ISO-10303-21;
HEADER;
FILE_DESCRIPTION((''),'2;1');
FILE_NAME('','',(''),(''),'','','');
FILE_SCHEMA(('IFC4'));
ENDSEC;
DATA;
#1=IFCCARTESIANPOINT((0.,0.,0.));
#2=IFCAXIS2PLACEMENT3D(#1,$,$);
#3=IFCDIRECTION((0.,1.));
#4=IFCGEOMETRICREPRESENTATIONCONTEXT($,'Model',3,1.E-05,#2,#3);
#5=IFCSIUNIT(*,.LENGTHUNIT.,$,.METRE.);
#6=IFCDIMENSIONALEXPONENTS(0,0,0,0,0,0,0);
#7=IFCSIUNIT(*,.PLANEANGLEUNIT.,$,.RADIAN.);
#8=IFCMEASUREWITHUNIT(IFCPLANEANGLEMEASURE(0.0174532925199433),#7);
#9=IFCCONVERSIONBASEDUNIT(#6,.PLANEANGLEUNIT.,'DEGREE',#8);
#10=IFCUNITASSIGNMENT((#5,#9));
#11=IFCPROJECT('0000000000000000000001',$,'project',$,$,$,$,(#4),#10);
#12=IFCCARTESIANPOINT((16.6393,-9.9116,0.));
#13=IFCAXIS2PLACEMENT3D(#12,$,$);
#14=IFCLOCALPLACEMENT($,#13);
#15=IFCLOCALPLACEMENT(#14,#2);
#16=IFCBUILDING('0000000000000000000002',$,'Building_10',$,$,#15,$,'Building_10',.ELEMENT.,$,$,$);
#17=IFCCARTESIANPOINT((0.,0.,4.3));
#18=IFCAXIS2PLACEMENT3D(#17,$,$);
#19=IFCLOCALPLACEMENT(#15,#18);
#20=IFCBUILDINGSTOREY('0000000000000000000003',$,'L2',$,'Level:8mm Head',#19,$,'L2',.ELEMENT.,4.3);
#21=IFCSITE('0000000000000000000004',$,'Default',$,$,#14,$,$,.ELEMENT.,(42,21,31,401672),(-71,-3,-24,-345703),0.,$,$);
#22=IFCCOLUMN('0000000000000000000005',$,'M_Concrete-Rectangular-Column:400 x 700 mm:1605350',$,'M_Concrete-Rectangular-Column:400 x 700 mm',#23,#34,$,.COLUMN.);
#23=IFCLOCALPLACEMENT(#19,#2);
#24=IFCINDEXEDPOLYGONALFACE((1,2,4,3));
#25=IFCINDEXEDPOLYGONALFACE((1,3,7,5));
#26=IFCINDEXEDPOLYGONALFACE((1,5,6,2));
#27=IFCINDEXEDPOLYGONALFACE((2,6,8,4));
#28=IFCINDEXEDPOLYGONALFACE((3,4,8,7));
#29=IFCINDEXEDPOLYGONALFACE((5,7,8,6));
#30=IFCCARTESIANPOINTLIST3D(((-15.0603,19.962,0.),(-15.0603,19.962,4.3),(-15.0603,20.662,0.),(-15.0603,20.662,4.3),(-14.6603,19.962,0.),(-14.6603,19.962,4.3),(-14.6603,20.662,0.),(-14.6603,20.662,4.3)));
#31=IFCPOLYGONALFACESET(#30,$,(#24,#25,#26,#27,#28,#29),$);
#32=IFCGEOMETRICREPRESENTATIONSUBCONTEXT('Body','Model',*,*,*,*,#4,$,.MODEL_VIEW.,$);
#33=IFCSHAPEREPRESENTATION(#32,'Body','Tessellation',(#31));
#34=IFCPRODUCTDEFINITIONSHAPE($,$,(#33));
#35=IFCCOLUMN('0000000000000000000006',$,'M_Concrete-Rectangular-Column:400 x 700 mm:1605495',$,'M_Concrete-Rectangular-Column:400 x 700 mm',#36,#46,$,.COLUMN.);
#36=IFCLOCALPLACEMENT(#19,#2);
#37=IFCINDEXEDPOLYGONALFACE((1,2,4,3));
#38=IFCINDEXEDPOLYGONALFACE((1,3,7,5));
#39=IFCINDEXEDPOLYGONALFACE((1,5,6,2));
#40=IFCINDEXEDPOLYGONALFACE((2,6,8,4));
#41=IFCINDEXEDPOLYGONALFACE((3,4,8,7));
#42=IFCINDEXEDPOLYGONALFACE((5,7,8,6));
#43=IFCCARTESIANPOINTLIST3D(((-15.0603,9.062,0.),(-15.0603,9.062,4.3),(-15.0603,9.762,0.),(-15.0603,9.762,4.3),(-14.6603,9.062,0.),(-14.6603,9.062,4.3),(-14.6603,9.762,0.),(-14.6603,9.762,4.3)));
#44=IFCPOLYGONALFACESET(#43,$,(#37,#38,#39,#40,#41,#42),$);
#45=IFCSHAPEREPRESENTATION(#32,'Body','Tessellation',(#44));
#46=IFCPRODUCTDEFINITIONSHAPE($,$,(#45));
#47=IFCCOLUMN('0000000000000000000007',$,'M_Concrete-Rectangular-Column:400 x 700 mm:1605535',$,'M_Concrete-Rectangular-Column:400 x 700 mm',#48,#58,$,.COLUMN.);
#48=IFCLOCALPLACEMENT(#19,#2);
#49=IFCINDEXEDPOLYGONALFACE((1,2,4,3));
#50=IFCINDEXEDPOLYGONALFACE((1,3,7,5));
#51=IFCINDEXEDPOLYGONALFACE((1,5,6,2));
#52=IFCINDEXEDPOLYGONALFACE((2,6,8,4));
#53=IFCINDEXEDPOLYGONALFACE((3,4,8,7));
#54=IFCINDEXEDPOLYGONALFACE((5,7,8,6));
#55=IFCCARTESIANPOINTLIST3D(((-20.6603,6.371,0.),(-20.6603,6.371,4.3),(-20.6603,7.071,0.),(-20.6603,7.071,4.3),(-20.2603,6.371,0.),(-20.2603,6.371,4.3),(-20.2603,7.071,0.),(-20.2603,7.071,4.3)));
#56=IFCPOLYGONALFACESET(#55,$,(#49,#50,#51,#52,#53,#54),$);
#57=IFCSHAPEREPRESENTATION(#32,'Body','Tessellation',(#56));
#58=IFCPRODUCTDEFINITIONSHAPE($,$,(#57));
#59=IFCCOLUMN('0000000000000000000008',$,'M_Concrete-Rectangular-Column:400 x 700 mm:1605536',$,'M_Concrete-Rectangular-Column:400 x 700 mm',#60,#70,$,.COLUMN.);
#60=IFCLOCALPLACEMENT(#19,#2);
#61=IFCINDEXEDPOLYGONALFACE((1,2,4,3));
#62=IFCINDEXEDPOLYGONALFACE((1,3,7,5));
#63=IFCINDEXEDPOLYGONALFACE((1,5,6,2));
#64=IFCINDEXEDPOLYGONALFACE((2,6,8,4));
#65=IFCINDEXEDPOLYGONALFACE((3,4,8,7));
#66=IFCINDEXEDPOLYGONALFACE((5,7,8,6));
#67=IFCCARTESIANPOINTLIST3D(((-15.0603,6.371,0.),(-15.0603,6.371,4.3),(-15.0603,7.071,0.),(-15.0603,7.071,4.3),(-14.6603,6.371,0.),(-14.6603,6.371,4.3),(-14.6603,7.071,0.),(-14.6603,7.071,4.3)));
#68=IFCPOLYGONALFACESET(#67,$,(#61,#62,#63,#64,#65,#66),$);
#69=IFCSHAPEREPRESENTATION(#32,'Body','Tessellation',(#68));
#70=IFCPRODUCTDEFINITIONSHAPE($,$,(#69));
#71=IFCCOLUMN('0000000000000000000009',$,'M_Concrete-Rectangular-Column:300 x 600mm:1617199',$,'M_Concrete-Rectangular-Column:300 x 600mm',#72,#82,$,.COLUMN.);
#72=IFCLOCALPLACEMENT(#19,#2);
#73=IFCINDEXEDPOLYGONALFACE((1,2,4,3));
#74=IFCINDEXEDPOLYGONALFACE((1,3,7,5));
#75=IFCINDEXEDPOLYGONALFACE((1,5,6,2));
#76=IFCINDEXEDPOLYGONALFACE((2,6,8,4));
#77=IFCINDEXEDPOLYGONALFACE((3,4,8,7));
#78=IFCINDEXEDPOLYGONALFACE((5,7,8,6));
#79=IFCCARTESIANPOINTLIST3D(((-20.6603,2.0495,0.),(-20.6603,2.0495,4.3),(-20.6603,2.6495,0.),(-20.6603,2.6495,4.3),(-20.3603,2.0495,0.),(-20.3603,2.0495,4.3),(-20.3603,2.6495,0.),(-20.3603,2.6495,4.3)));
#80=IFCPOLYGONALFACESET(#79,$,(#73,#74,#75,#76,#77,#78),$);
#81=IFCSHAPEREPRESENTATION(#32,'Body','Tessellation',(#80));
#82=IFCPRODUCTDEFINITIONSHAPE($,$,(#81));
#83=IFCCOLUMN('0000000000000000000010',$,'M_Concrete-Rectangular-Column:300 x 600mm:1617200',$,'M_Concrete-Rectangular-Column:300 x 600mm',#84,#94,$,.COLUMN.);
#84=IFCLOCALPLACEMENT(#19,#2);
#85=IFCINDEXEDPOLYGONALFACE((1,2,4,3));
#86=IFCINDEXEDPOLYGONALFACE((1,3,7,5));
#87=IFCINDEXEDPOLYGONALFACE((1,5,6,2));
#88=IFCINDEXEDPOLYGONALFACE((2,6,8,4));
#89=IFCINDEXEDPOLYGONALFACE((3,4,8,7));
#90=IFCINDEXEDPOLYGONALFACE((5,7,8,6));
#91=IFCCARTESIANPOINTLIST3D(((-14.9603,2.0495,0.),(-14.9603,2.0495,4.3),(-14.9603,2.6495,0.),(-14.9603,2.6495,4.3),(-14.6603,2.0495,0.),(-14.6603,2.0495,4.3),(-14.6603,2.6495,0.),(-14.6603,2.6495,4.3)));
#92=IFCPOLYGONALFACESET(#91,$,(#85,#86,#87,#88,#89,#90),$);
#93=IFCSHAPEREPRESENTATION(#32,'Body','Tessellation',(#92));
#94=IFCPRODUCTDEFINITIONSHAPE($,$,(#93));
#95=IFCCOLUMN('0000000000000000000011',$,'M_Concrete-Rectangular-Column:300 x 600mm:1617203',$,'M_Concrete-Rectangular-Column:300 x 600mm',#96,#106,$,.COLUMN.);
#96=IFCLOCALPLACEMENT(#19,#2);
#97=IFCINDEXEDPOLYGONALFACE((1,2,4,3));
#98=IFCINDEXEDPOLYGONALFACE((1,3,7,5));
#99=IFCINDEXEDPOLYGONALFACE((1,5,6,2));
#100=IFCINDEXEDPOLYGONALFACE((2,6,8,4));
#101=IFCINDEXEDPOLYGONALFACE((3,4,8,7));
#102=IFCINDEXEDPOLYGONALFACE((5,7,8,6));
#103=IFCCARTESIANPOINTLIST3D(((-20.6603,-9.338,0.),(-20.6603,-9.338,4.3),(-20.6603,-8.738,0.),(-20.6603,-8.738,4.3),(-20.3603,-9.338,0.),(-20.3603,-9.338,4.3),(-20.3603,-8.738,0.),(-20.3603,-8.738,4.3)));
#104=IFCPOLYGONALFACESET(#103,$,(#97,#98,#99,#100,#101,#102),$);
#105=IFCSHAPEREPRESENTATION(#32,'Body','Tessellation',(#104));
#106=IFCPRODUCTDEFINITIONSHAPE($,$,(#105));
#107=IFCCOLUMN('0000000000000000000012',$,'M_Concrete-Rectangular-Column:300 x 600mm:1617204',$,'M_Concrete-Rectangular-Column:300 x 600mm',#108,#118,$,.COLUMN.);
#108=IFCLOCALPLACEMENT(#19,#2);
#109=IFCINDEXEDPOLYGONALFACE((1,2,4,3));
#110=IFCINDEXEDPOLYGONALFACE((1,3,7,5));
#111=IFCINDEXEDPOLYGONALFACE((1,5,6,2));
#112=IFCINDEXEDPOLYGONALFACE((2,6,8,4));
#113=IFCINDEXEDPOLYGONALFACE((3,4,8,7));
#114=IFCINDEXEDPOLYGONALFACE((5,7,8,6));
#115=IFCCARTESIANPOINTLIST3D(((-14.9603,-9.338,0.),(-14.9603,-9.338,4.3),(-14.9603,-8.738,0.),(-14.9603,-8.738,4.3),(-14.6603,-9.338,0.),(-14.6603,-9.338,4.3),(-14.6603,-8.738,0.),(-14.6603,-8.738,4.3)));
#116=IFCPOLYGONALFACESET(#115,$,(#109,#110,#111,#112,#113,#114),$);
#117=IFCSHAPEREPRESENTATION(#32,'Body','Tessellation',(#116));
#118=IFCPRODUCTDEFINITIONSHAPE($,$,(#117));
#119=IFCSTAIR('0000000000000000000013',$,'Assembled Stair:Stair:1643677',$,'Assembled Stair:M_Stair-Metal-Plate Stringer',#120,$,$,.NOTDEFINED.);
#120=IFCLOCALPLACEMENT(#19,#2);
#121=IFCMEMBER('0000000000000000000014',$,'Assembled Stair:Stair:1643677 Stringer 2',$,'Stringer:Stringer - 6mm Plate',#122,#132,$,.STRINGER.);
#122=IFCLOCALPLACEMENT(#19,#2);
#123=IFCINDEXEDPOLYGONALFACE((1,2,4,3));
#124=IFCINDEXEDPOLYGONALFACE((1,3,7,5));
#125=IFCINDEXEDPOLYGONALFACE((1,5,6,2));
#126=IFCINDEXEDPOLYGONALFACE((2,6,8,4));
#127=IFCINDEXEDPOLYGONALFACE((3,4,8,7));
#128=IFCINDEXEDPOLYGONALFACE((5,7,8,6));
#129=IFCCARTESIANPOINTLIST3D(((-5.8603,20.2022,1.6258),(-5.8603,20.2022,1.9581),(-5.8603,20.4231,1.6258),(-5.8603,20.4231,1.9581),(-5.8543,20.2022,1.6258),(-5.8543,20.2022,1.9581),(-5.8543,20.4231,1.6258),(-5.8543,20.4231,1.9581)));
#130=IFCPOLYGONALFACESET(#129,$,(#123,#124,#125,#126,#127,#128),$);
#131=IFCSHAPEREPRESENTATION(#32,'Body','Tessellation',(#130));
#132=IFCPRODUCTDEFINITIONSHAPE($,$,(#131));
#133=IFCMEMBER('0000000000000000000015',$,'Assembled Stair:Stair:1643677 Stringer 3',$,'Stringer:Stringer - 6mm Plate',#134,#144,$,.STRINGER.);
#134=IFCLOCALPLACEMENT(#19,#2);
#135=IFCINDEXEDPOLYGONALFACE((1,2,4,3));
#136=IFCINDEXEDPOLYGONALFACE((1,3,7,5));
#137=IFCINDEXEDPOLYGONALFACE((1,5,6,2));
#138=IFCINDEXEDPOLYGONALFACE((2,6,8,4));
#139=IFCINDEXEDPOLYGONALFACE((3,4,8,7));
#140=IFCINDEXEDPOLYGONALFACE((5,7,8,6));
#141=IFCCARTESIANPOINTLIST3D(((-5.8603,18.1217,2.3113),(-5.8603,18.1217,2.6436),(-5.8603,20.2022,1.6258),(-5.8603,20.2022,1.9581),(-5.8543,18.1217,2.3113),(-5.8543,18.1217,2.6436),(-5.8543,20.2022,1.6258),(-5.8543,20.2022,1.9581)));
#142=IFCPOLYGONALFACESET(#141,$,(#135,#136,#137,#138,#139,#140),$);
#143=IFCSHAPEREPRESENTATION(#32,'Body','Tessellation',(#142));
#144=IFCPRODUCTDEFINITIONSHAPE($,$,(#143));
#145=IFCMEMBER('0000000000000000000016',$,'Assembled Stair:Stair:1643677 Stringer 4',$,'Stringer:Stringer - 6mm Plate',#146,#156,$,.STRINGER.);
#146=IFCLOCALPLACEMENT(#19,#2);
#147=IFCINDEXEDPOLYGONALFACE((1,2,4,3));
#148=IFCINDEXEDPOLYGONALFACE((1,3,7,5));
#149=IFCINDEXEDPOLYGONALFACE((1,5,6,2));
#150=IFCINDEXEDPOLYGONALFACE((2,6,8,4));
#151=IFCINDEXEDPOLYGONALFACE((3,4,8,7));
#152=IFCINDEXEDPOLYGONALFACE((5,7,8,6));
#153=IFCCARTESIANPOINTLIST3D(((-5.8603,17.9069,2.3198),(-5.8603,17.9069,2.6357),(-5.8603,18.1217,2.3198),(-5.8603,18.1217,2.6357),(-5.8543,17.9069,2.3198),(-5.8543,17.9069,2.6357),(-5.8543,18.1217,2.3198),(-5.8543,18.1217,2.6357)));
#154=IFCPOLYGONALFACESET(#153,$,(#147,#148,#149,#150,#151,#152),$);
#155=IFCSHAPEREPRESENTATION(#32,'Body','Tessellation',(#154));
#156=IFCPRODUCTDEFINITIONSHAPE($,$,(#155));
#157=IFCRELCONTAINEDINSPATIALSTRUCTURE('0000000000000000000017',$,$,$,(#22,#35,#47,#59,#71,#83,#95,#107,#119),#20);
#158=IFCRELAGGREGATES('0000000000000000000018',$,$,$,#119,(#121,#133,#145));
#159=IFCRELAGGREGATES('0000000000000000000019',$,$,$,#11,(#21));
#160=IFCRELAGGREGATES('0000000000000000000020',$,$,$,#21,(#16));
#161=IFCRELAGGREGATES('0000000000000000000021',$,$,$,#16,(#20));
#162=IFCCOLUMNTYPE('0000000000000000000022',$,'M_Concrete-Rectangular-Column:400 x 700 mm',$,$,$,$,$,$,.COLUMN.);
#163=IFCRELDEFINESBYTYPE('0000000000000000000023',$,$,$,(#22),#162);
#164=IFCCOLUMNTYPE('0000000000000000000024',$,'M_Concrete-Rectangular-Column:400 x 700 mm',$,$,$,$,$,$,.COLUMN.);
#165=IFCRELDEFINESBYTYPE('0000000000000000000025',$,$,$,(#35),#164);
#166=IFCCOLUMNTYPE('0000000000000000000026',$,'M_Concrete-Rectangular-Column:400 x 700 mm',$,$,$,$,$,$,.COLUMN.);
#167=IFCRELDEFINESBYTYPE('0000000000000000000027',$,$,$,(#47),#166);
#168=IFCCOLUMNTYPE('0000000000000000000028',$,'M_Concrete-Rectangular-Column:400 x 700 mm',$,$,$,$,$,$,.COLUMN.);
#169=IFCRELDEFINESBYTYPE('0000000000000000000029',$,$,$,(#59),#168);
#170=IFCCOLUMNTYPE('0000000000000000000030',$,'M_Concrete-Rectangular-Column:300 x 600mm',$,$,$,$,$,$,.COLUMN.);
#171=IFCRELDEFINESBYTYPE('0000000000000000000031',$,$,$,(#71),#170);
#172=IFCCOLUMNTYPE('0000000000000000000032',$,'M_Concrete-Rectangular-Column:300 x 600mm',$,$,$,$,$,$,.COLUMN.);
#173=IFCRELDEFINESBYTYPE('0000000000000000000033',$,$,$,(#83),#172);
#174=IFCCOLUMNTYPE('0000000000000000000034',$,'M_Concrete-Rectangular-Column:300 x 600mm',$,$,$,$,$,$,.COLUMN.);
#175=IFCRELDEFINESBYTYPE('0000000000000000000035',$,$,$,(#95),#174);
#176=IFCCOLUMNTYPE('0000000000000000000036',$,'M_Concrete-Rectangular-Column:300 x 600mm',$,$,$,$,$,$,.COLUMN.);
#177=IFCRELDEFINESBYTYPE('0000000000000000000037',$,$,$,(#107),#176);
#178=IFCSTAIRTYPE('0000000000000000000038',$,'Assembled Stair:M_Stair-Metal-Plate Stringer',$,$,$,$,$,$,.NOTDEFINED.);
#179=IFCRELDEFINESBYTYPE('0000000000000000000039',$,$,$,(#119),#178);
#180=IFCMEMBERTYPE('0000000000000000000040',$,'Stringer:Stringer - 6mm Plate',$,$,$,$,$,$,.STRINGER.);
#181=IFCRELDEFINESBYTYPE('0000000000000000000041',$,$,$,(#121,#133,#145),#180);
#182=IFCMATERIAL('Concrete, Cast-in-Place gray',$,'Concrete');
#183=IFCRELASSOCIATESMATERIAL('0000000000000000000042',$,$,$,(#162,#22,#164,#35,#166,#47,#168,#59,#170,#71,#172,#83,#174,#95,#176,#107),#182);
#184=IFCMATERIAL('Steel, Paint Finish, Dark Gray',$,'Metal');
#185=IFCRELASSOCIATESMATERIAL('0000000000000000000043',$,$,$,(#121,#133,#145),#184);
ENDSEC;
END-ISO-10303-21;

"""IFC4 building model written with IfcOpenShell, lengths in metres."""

from ifc_helpers import new_model, entity, si_unit, converted_unit, direction, frame, origin, place, context, subcontext, project, spatial, indexed_curve, outline, extrude, source, transform, mapped, material, type_object, type_shapes, element, aggregate, save


model = new_model("IFC4")

# Units and contexts
model_context = context("Model", 3, precision=1e-05, world=origin(), true_north=direction((0.0, 1.0)))
body_context = subcontext(model_context, "Body", "Model", "MODEL_VIEW")
ifc_project = project(units=[si_unit("LENGTHUNIT", "METRE"), converted_unit("PLANEANGLEUNIT", "DEGREE", entity("IfcPlaneAngleMeasure", 0.0174532925199433), si_unit("PLANEANGLEUNIT", "RADIAN"), dimensions=[0, 0, 0, 0, 0, 0, 0])], contexts=[model_context])

# Site, building, storey
site_placement = place(None, frame((16.6393, -9.9116, 0.0)))
site = spatial("IfcSite", under=ifc_project, at=site_placement, Name="Default", CompositionType="ELEMENT", RefLatitude=(42, 21, 31, 401672), RefLongitude=(-71, -3, -24, -345703), RefElevation=0.0)
building_placement = place(site_placement, origin())
building = spatial("IfcBuilding", under=site, at=building_placement, Name="Building_10", LongName="Building_10", CompositionType="ELEMENT")
storey_placement = place(building_placement, frame((0.0, 0.0, 4.3)))
storey = spatial("IfcBuildingStorey", under=building, at=storey_placement, Name="L2", ObjectType="Level:8mm Head", LongName="L2", CompositionType="ELEMENT", Elevation=4.3)

# Columns
ifc_material_1 = material(Name="Concrete, Cast-in-Place gray", Category="Concrete")
column_type_1 = type_object("IfcColumnType", Name="M_Concrete-Rectangular-Column:400 x 700 mm", PredefinedType="COLUMN", material=ifc_material_1)
shared_shape_1 = source(origin(), body_context, "Body", "SweptSolid", [
    extrude(outline(indexed_curve([(-0.2, -0.35), (0.2, -0.35), (0.2, 0.35), (-0.2, 0.35), (-0.2, -0.35)], self_intersect=False)), frame((-14.8603, 20.312, 4.3), z_axis=(0.0, 0.0, 1.0), x_axis=(-1.0, 0.0, 0.0)), (0.0, 0.0, 1.0), 4.3),
])
type_shapes(column_type_1, [shared_shape_1])
column_1_placement = place(storey_placement, frame((0.0, 0.0, -4.3)))
element("IfcColumn", 1, at=column_1_placement, inside=storey, type_object=column_type_1, material=ifc_material_1, Name="M_Concrete-Rectangular-Column:400 x 700 mm:1605350", ObjectType="M_Concrete-Rectangular-Column:400 x 700 mm", PredefinedType="COLUMN", context=body_context, shape_type="MappedRepresentation", body=[
    mapped(shared_shape_1, transform((0.0, 0.0, 0.0), scale=1.0)),
])
column_type_2 = type_object("IfcColumnType", Name="M_Concrete-Rectangular-Column:400 x 700 mm", PredefinedType="COLUMN", material=ifc_material_1)
shared_shape_2 = source(origin(), body_context, "Body", "SweptSolid", [
    extrude(outline(indexed_curve([(-0.2, -0.35), (0.2, -0.35), (0.2, 0.35), (-0.2, 0.35), (-0.2, -0.35)], self_intersect=False)), frame((-14.8603, 9.412, 4.3), z_axis=(0.0, 0.0, 1.0), x_axis=(-1.0, 0.0, 0.0)), (0.0, 0.0, 1.0), 4.3),
])
type_shapes(column_type_2, [shared_shape_2])
column_2_placement = place(storey_placement, frame((0.0, 0.0, -4.3)))
element("IfcColumn", 2, at=column_2_placement, inside=storey, type_object=column_type_2, material=ifc_material_1, Name="M_Concrete-Rectangular-Column:400 x 700 mm:1605495", ObjectType="M_Concrete-Rectangular-Column:400 x 700 mm", PredefinedType="COLUMN", context=body_context, shape_type="MappedRepresentation", body=[
    mapped(shared_shape_2, transform((0.0, 0.0, 0.0), scale=1.0)),
])
column_type_3 = type_object("IfcColumnType", Name="M_Concrete-Rectangular-Column:400 x 700 mm", PredefinedType="COLUMN", material=ifc_material_1)
shared_shape_3 = source(origin(), body_context, "Body", "SweptSolid", [
    extrude(outline(indexed_curve([(-2.15, -0.35), (2.15, -0.35), (2.15, 0.35), (-2.15, 0.35), (-2.15, -0.35)], self_intersect=False)), frame((-20.6603, 6.721, 6.45), z_axis=(1.0, 0.0, 0.0), x_axis=(0.0, 0.0, 1.0)), (0.0, 0.0, 1.0), 0.4),
])
type_shapes(column_type_3, [shared_shape_3])
column_3_placement = place(storey_placement, frame((0.0, 0.0, -4.3)))
element("IfcColumn", 3, at=column_3_placement, inside=storey, type_object=column_type_3, material=ifc_material_1, Name="M_Concrete-Rectangular-Column:400 x 700 mm:1605535", ObjectType="M_Concrete-Rectangular-Column:400 x 700 mm", PredefinedType="COLUMN", context=body_context, shape_type="MappedRepresentation", body=[
    mapped(shared_shape_3, transform((0.0, 0.0, 0.0), scale=1.0)),
])
column_type_4 = type_object("IfcColumnType", Name="M_Concrete-Rectangular-Column:400 x 700 mm", PredefinedType="COLUMN", material=ifc_material_1)
shared_shape_4 = source(origin(), body_context, "Body", "SweptSolid", [
    extrude(outline(indexed_curve([(-2.15, -0.35), (2.15, -0.35), (2.15, 0.35), (-2.15, 0.35), (-2.15, -0.35)], self_intersect=False)), frame((-15.0603, 6.721, 6.45), z_axis=(1.0, 0.0, 0.0), x_axis=(0.0, 0.0, 1.0)), (0.0, 0.0, 1.0), 0.4),
])
type_shapes(column_type_4, [shared_shape_4])
column_4_placement = place(storey_placement, frame((0.0, 0.0, -4.3)))
element("IfcColumn", 4, at=column_4_placement, inside=storey, type_object=column_type_4, material=ifc_material_1, Name="M_Concrete-Rectangular-Column:400 x 700 mm:1605536", ObjectType="M_Concrete-Rectangular-Column:400 x 700 mm", PredefinedType="COLUMN", context=body_context, shape_type="MappedRepresentation", body=[
    mapped(shared_shape_4, transform((0.0, 0.0, 0.0), scale=1.0)),
])
column_type_5 = type_object("IfcColumnType", Name="M_Concrete-Rectangular-Column:300 x 600mm", PredefinedType="COLUMN", material=ifc_material_1)
shared_shape_5 = source(origin(), body_context, "Body", "SweptSolid", [
    extrude(outline(indexed_curve([(-0.15, -0.3), (0.15, -0.3), (0.15, 0.3), (-0.15, 0.3), (-0.15, -0.3)], self_intersect=False)), frame((-20.5103, 2.3495, 4.3), z_axis=(0.0, 0.0, 1.0), x_axis=(-1.0, 0.0, 0.0)), (0.0, 0.0, 1.0), 4.3),
])
type_shapes(column_type_5, [shared_shape_5])
column_5_placement = place(storey_placement, frame((0.0, 0.0, -4.3)))
element("IfcColumn", 5, at=column_5_placement, inside=storey, type_object=column_type_5, material=ifc_material_1, Name="M_Concrete-Rectangular-Column:300 x 600mm:1617199", ObjectType="M_Concrete-Rectangular-Column:300 x 600mm", PredefinedType="COLUMN", context=body_context, shape_type="MappedRepresentation", body=[
    mapped(shared_shape_5, transform((0.0, 0.0, 0.0), scale=1.0)),
])
column_type_6 = type_object("IfcColumnType", Name="M_Concrete-Rectangular-Column:300 x 600mm", PredefinedType="COLUMN", material=ifc_material_1)
shared_shape_6 = source(origin(), body_context, "Body", "SweptSolid", [
    extrude(outline(indexed_curve([(-0.15, -0.3), (0.15, -0.3), (0.15, 0.3), (-0.15, 0.3), (-0.15, -0.3)], self_intersect=False)), frame((-14.8103, 2.3495, 4.3), z_axis=(0.0, 0.0, 1.0), x_axis=(-1.0, 0.0, 0.0)), (0.0, 0.0, 1.0), 4.3),
])
type_shapes(column_type_6, [shared_shape_6])
column_6_placement = place(storey_placement, frame((0.0, 0.0, -4.3)))
element("IfcColumn", 6, at=column_6_placement, inside=storey, type_object=column_type_6, material=ifc_material_1, Name="M_Concrete-Rectangular-Column:300 x 600mm:1617200", ObjectType="M_Concrete-Rectangular-Column:300 x 600mm", PredefinedType="COLUMN", context=body_context, shape_type="MappedRepresentation", body=[
    mapped(shared_shape_6, transform((0.0, 0.0, 0.0), scale=1.0)),
])
column_type_7 = type_object("IfcColumnType", Name="M_Concrete-Rectangular-Column:300 x 600mm", PredefinedType="COLUMN", material=ifc_material_1)
shared_shape_7 = source(origin(), body_context, "Body", "SweptSolid", [
    extrude(outline(indexed_curve([(-0.15, -0.3), (0.15, -0.3), (0.15, 0.3), (-0.15, 0.3), (-0.15, -0.3)], self_intersect=False)), frame((-20.5103, -9.038, 4.3), z_axis=(0.0, 0.0, 1.0), x_axis=(-1.0, 0.0, 0.0)), (0.0, 0.0, 1.0), 4.3),
])
type_shapes(column_type_7, [shared_shape_7])
column_7_placement = place(storey_placement, frame((0.0, 0.0, -4.3)))
element("IfcColumn", 7, at=column_7_placement, inside=storey, type_object=column_type_7, material=ifc_material_1, Name="M_Concrete-Rectangular-Column:300 x 600mm:1617203", ObjectType="M_Concrete-Rectangular-Column:300 x 600mm", PredefinedType="COLUMN", context=body_context, shape_type="MappedRepresentation", body=[
    mapped(shared_shape_7, transform((0.0, 0.0, 0.0), scale=1.0)),
])
column_type_8 = type_object("IfcColumnType", Name="M_Concrete-Rectangular-Column:300 x 600mm", PredefinedType="COLUMN", material=ifc_material_1)
shared_shape_8 = source(origin(), body_context, "Body", "SweptSolid", [
    extrude(outline(indexed_curve([(-0.15, -0.3), (0.15, -0.3), (0.15, 0.3), (-0.15, 0.3), (-0.15, -0.3)], self_intersect=False)), frame((-14.8103, -9.038, 4.3), z_axis=(0.0, 0.0, 1.0), x_axis=(-1.0, 0.0, 0.0)), (0.0, 0.0, 1.0), 4.3),
])
type_shapes(column_type_8, [shared_shape_8])
column_8_placement = place(storey_placement, frame((0.0, 0.0, -4.3)))
element("IfcColumn", 8, at=column_8_placement, inside=storey, type_object=column_type_8, material=ifc_material_1, Name="M_Concrete-Rectangular-Column:300 x 600mm:1617204", ObjectType="M_Concrete-Rectangular-Column:300 x 600mm", PredefinedType="COLUMN", context=body_context, shape_type="MappedRepresentation", body=[
    mapped(shared_shape_8, transform((0.0, 0.0, 0.0), scale=1.0)),
])

# Stair, members
stair_type = type_object("IfcStairType", Name="Assembled Stair:M_Stair-Metal-Plate Stringer", PredefinedType="NOTDEFINED")
stair_1_placement = place(storey_placement, origin())
stair_1 = element("IfcStair", 9, at=stair_1_placement, inside=storey, type_object=stair_type, Name="Assembled Stair:Stair:1643677", ObjectType="Assembled Stair:M_Stair-Metal-Plate Stringer", PredefinedType="NOTDEFINED")
ifc_material_2 = material(Name="Steel, Paint Finish, Dark Gray", Category="Metal")
member_type = type_object("IfcMemberType", Name="Stringer:Stringer - 6mm Plate", PredefinedType="STRINGER")
member_1_placement = place(stair_1_placement, origin())
member_1 = element("IfcMember", 10, at=member_1_placement, type_object=member_type, material=ifc_material_2, Name="Assembled Stair:Stair:1643677 Stringer 2", ObjectType="Stringer:Stringer - 6mm Plate", PredefinedType="STRINGER", context=body_context, shape_type="SweptSolid", body=[
    extrude(outline(indexed_curve([(-0.1104, -0.003), (0.1104, -0.003), (0.1104, 0.003), (-0.1104, 0.003), (-0.1104, -0.003)], self_intersect=False)), frame((-5.8573, 20.3126, 1.6258), z_axis=(0.0, 0.0, 1.0), x_axis=(0.0, -1.0, 0.0)), (0.0, 0.0, 1.0), 0.3323),
])
member_2_placement = place(stair_1_placement, origin())
member_2 = element("IfcMember", 11, at=member_2_placement, type_object=member_type, material=ifc_material_2, Name="Assembled Stair:Stair:1643677 Stringer 3", ObjectType="Stringer:Stringer - 6mm Plate", PredefinedType="STRINGER", context=body_context, shape_type="SweptSolid", body=[
    extrude(outline(indexed_curve([(-1.0433, -0.1578), (1.1473, -0.1578), (1.0433, 0.1578), (-1.1473, 0.1578), (-1.0433, -0.1578)], self_intersect=False)), frame((-5.8603, 19.162, 2.1347), z_axis=(1.0, 0.0, 0.0), x_axis=(0.0, -0.949774, 0.312936)), (0.0, 0.0, 1.0), 0.006),
])
member_3_placement = place(stair_1_placement, origin())
member_3 = element("IfcMember", 12, at=member_3_placement, type_object=member_type, material=ifc_material_2, Name="Assembled Stair:Stair:1643677 Stringer 4", ObjectType="Stringer:Stringer - 6mm Plate", PredefinedType="STRINGER", context=body_context, shape_type="SweptSolid", body=[
    extrude(outline(indexed_curve([(-0.1074, -0.003), (0.1074, -0.003), (0.1074, 0.003), (-0.1074, 0.003), (-0.1074, -0.003)], self_intersect=False)), frame((-5.8573, 18.0143, 2.3198), z_axis=(0.0, 0.0, 1.0), x_axis=(0.0, -1.0, 0.0)), (0.0, 0.0, 1.0), 0.3159),
])
aggregate(stair_1, [member_1, member_2, member_3])

save(model, "model.ifc")
